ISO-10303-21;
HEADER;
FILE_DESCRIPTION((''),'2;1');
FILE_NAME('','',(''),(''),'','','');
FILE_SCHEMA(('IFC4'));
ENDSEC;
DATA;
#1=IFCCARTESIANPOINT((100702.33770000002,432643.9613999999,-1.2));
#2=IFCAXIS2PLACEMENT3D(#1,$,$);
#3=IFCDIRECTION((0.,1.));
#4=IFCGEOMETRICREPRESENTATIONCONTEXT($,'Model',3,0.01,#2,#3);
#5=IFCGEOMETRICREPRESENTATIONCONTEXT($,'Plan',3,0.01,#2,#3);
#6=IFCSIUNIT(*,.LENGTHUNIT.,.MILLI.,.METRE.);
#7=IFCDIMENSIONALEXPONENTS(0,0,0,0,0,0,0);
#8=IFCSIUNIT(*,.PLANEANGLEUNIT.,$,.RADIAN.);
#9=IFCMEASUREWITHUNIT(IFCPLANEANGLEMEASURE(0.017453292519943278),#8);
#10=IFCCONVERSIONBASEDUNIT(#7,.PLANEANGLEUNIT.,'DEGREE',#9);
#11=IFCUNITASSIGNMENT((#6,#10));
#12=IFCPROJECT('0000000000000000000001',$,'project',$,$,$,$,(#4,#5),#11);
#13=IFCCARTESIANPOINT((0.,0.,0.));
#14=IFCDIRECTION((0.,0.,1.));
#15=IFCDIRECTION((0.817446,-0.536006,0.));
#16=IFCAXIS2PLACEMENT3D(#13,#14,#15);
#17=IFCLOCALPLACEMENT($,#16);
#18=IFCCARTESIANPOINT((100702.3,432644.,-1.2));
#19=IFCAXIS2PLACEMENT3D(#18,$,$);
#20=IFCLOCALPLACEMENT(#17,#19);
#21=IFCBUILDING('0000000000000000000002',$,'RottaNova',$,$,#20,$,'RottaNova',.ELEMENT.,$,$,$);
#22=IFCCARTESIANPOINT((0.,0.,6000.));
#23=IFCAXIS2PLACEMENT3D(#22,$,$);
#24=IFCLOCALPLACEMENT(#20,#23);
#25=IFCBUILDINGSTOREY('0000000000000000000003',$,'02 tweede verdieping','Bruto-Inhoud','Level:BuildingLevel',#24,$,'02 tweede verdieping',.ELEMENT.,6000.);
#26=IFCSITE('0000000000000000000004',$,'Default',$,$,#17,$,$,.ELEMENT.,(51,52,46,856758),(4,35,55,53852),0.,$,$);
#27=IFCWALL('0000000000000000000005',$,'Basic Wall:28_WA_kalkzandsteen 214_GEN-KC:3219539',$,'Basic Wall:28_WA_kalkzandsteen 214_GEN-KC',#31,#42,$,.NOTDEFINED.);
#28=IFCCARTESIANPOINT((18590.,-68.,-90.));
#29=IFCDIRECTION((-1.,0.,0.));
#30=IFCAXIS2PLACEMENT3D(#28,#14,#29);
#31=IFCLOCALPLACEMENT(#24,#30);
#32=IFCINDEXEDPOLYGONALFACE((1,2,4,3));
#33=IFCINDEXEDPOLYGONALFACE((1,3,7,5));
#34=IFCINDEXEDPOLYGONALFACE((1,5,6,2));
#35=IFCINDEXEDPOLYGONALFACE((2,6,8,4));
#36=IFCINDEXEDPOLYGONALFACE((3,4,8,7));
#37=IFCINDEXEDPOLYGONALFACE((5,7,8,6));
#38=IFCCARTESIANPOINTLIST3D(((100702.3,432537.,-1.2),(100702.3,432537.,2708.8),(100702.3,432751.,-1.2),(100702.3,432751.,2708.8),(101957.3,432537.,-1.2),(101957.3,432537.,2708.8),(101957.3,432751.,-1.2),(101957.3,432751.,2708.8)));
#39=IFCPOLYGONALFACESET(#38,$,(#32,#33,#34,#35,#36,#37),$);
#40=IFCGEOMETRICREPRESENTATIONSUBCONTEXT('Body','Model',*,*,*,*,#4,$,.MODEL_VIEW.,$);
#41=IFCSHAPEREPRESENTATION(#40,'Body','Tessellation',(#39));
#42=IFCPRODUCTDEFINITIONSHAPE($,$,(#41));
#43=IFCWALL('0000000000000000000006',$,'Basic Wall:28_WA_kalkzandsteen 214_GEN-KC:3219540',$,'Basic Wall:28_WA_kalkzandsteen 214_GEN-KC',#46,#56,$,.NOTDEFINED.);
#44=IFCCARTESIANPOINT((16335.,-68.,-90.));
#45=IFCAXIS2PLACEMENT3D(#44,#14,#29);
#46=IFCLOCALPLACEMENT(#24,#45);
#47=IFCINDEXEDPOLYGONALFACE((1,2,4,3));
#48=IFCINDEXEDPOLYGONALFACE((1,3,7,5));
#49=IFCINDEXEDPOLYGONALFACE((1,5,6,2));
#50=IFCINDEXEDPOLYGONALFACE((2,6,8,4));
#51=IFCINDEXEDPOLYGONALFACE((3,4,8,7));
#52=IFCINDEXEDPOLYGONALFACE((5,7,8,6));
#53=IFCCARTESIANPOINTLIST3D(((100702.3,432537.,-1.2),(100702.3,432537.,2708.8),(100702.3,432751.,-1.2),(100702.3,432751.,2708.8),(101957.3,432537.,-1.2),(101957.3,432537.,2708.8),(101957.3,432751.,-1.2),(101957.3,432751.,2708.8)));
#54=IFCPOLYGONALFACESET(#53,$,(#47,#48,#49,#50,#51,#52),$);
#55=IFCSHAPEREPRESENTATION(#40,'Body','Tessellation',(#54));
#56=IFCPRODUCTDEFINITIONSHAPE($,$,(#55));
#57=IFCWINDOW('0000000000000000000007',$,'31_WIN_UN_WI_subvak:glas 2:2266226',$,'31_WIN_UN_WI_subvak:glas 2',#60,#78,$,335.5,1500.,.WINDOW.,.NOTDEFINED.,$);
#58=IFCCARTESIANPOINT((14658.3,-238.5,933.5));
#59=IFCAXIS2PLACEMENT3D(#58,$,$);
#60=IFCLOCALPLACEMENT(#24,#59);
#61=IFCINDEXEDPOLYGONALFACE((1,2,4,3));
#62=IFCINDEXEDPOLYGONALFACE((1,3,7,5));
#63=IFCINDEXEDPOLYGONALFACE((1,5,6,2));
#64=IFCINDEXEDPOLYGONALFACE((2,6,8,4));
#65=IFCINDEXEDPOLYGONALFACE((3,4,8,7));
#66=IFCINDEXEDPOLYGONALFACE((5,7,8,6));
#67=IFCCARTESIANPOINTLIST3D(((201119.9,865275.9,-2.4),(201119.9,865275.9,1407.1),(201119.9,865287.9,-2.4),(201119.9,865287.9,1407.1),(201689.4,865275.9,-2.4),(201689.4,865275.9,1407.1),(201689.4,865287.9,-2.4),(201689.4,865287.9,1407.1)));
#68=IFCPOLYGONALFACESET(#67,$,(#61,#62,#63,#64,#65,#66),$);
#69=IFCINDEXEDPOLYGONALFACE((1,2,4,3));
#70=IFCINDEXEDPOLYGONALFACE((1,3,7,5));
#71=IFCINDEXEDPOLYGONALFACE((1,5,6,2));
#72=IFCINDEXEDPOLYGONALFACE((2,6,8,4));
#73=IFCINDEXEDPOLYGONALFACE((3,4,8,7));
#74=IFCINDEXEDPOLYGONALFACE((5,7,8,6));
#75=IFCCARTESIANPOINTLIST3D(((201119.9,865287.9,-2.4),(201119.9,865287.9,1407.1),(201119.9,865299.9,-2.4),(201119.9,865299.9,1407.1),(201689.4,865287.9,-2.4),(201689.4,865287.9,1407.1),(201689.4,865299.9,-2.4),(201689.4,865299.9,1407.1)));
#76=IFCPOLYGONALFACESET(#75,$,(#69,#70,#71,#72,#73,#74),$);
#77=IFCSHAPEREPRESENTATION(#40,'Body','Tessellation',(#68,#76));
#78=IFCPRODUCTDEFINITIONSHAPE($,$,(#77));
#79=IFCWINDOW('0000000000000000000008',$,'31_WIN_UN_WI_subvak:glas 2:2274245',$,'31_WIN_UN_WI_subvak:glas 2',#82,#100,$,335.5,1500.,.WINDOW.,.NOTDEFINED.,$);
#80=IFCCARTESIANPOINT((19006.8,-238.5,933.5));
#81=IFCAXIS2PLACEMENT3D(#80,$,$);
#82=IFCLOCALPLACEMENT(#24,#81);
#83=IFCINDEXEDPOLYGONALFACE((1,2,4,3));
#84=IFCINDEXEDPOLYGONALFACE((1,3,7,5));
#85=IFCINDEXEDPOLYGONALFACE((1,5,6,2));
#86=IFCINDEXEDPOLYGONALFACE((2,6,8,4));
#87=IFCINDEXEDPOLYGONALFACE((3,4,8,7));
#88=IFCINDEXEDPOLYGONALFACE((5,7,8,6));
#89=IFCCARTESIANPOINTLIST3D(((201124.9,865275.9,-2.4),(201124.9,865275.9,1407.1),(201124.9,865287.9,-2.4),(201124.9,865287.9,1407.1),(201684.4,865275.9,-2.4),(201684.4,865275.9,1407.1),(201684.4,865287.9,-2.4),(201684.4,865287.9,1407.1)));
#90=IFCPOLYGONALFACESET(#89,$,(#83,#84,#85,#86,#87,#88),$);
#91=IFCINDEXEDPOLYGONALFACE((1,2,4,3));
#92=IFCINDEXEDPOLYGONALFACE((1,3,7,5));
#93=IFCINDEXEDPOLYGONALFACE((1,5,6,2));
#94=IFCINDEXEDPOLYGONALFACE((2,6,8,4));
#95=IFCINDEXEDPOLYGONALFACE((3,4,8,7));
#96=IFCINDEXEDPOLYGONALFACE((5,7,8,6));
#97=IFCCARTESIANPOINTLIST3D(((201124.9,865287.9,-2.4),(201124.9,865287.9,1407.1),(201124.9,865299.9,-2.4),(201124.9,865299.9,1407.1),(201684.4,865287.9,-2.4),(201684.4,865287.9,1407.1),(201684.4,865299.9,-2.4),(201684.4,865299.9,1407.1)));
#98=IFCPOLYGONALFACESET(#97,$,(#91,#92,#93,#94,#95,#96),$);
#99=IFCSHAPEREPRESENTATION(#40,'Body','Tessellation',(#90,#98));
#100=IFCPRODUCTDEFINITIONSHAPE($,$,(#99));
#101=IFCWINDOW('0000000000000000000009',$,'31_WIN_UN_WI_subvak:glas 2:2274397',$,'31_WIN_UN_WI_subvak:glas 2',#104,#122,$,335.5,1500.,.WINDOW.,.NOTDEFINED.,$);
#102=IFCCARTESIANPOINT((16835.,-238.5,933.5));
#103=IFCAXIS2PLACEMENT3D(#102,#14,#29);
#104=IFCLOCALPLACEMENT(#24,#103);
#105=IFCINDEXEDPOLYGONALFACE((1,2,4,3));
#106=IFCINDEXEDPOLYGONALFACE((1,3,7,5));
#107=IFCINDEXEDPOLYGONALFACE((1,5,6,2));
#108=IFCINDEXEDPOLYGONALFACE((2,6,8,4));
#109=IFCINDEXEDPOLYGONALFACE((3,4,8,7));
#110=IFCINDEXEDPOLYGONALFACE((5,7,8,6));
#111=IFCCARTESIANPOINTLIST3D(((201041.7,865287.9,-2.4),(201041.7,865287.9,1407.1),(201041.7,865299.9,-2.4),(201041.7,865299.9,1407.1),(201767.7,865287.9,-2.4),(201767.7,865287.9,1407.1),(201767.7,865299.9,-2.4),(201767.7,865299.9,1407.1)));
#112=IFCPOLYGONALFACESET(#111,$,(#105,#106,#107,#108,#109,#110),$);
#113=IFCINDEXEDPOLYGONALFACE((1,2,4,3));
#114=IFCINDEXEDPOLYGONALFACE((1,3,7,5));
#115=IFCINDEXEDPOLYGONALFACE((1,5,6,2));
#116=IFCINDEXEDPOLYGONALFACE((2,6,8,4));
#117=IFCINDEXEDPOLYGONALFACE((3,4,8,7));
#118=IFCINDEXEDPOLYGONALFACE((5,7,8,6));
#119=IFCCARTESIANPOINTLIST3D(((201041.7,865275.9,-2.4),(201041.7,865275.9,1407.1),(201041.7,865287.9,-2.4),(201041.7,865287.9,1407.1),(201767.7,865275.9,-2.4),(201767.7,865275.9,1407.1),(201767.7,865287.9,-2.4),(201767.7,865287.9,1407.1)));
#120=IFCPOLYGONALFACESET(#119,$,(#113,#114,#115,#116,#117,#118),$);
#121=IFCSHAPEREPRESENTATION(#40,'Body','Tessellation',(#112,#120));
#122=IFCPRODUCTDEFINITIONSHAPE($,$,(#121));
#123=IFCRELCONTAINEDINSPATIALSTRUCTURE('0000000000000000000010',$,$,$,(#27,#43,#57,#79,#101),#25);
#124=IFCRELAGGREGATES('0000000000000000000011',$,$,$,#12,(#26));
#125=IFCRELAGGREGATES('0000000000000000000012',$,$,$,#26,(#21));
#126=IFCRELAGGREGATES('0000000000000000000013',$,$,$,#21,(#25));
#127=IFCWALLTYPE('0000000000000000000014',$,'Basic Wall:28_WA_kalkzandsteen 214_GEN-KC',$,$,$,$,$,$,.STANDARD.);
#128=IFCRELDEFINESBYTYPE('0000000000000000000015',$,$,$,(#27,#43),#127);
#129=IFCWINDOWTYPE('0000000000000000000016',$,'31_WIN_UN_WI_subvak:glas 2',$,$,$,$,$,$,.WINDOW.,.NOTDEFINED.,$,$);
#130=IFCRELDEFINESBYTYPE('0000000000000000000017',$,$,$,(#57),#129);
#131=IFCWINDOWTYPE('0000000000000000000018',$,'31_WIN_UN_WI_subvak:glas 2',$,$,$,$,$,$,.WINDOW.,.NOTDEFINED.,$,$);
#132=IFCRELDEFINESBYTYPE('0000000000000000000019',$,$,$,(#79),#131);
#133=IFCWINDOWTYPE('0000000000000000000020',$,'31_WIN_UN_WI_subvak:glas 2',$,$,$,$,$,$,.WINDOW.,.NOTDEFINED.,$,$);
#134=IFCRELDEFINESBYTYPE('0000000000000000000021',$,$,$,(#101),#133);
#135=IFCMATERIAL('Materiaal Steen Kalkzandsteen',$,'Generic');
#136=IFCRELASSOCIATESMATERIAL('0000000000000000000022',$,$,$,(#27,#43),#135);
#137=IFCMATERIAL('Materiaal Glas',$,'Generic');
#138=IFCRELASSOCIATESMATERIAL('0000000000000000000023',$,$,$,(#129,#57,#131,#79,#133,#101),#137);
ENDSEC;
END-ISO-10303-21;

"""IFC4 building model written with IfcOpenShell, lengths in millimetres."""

from ifc_helpers import new_model, entity, si_unit, converted_unit, direction, frame, place, context, subcontext, project, spatial, indexed_curve, outline, extrude, source, transform, mapped, material, type_object, type_shapes, element, save


model = new_model("IFC4")

# Units and contexts
model_context = context("Model", 3, precision=0.01, world=frame((100702.33770000002, 432643.9613999999, -1.2)), true_north=direction((0.0, 1.0)))
plan_context = context("Plan", 3, precision=0.01, world=frame((100702.33770000002, 432643.9613999999, -1.2)), true_north=direction((0.0, 1.0)))
body_context = subcontext(model_context, "Body", "Model", "MODEL_VIEW")
ifc_project = project(units=[si_unit("LENGTHUNIT", "METRE", prefix="MILLI"), converted_unit("PLANEANGLEUNIT", "DEGREE", entity("IfcPlaneAngleMeasure", 0.017453292519943278), si_unit("PLANEANGLEUNIT", "RADIAN"), dimensions=[0, 0, 0, 0, 0, 0, 0])], contexts=[model_context, plan_context])

# Site, building, storey
site_placement = place(None, frame((0.0, 0.0, 0.0), z_axis=(0.0, 0.0, 1.0), x_axis=(0.817446, -0.536006, 0.0)))
site = spatial("IfcSite", under=ifc_project, at=site_placement, Name="Default", CompositionType="ELEMENT", RefLatitude=(51, 52, 46, 856758), RefLongitude=(4, 35, 55, 53852), RefElevation=0.0)
building_placement = place(site_placement, frame((100702.3, 432644.0, -1.2)))
building = spatial("IfcBuilding", under=site, at=building_placement, Name="RottaNova", LongName="RottaNova", CompositionType="ELEMENT")
storey_placement = place(building_placement, frame((0.0, 0.0, 6000.0)))
storey = spatial("IfcBuildingStorey", under=building, at=storey_placement, Name="02 tweede verdieping", Description="Bruto-Inhoud", ObjectType="Level:BuildingLevel", LongName="02 tweede verdieping", CompositionType="ELEMENT", Elevation=6000.0)

# Shared definitions
ifc_material_1 = material(Name="Materiaal Glas", Category="Generic")

# Walls
ifc_material_2 = material(Name="Materiaal Steen Kalkzandsteen", Category="Generic")
wall_type = type_object("IfcWallType", Name="Basic Wall:28_WA_kalkzandsteen 214_GEN-KC", PredefinedType="STANDARD")
wall_1_placement = place(storey_placement, frame((18590.0, -68.0, -90.0), z_axis=(0.0, 0.0, 1.0), x_axis=(-1.0, 0.0, 0.0)))
element("IfcWall", 1, at=wall_1_placement, inside=storey, type_object=wall_type, material=ifc_material_2, Name="Basic Wall:28_WA_kalkzandsteen 214_GEN-KC:3219539", ObjectType="Basic Wall:28_WA_kalkzandsteen 214_GEN-KC", PredefinedType="NOTDEFINED", context=body_context, shape_type="SweptSolid", body=[
    extrude(outline(indexed_curve([(1255.0, 107.0), (0.0, 107.0), (0.0, -107.0), (1255.0, -107.0), (1255.0, 107.0)], self_intersect=False)), frame((100702.3, 432644.0, -1.2)), (0.0, 0.0, 1.0), 2710.0),
])
wall_2_placement = place(storey_placement, frame((16335.0, -68.0, -90.0), z_axis=(0.0, 0.0, 1.0), x_axis=(-1.0, 0.0, 0.0)))
element("IfcWall", 2, at=wall_2_placement, inside=storey, type_object=wall_type, material=ifc_material_2, Name="Basic Wall:28_WA_kalkzandsteen 214_GEN-KC:3219540", ObjectType="Basic Wall:28_WA_kalkzandsteen 214_GEN-KC", PredefinedType="NOTDEFINED", context=body_context, shape_type="SweptSolid", body=[
    extrude(outline(indexed_curve([(1255.0, 107.0), (0.0, 107.0), (0.0, -107.0), (1255.0, -107.0), (1255.0, 107.0)], self_intersect=False)), frame((100702.3, 432644.0, -1.2)), (0.0, 0.0, 1.0), 2710.0),
])

# Windows
window_type_1 = type_object("IfcWindowType", Name="31_WIN_UN_WI_subvak:glas 2", PartitioningType="NOTDEFINED", PredefinedType="WINDOW", material=ifc_material_1)
shared_shape_1 = source(frame((100702.3, 432644.0, -1.2)), body_context, "Body", "SweptSolid", [
    extrude(outline(indexed_curve([(-284.7, -6.0), (284.7, -6.0), (284.7, 6.0), (-284.7, 6.0), (-284.7, -6.0)], self_intersect=False)), frame((0.0, -6.0, 0.0)), (0.0, 0.0, 1.0), 1409.5),
    extrude(outline(indexed_curve([(-284.8, -6.0), (284.8, -6.0), (284.8, 6.0), (-284.8, 6.0), (-284.8, -6.0)], self_intersect=False)), frame((0.0, 6.0, 0.0)), (0.0, 0.0, 1.0), 1409.5),
])
type_shapes(window_type_1, [shared_shape_1])
window_1_placement = place(storey_placement, frame((14658.3, -238.5, 933.5)))
element("IfcWindow", 3, at=window_1_placement, inside=storey, type_object=window_type_1, material=ifc_material_1, Name="31_WIN_UN_WI_subvak:glas 2:2266226", ObjectType="31_WIN_UN_WI_subvak:glas 2", OverallHeight=335.5, OverallWidth=1500.0, PartitioningType="NOTDEFINED", PredefinedType="WINDOW", context=body_context, shape_type="MappedRepresentation", body=[
    mapped(shared_shape_1, transform((100702.3, 432644.0, -1.2), scale=1.0)),
])
window_type_2 = type_object("IfcWindowType", Name="31_WIN_UN_WI_subvak:glas 2", PartitioningType="NOTDEFINED", PredefinedType="WINDOW", material=ifc_material_1)
shared_shape_2 = source(frame((100702.3, 432644.0, -1.2)), body_context, "Body", "SweptSolid", [
    extrude(outline(indexed_curve([(-279.8, -6.0), (279.8, -6.0), (279.8, 6.0), (-279.8, 6.0), (-279.8, -6.0)], self_intersect=False)), frame((0.0, -6.0, 0.0)), (0.0, 0.0, 1.0), 1409.5),
    extrude(outline(indexed_curve([(-279.8, -6.0), (279.8, -6.0), (279.8, 6.0), (-279.8, 6.0), (-279.8, -6.0)], self_intersect=False)), frame((0.0, 6.0, 0.0)), (0.0, 0.0, 1.0), 1409.5),
])
type_shapes(window_type_2, [shared_shape_2])
window_2_placement = place(storey_placement, frame((19006.8, -238.5, 933.5)))
element("IfcWindow", 4, at=window_2_placement, inside=storey, type_object=window_type_2, material=ifc_material_1, Name="31_WIN_UN_WI_subvak:glas 2:2274245", ObjectType="31_WIN_UN_WI_subvak:glas 2", OverallHeight=335.5, OverallWidth=1500.0, PartitioningType="NOTDEFINED", PredefinedType="WINDOW", context=body_context, shape_type="MappedRepresentation", body=[
    mapped(shared_shape_2, transform((100702.3, 432644.0, -1.2), scale=1.0)),
])
window_type_3 = type_object("IfcWindowType", Name="31_WIN_UN_WI_subvak:glas 2", PartitioningType="NOTDEFINED", PredefinedType="WINDOW", material=ifc_material_1)
shared_shape_3 = source(frame((100702.3, 432644.0, -1.2)), body_context, "Body", "SweptSolid", [
    extrude(outline(indexed_curve([(-6.0, -363.0), (6.0, -363.0), (6.0, 363.0), (-6.0, 363.0), (-6.0, -363.0)], self_intersect=False)), frame((0.0, 6.0, 0.0), z_axis=(0.0, 0.0, 1.0), x_axis=(0.0, -1.0, 0.0)), (0.0, 0.0, 1.0), 1409.5),
    extrude(outline(indexed_curve([(-6.0, -363.0), (6.0, -363.0), (6.0, 363.0), (-6.0, 363.0), (-6.0, -363.0)], self_intersect=False)), frame((0.0, -6.0, 0.0), z_axis=(0.0, 0.0, 1.0), x_axis=(0.0, -1.0, 0.0)), (0.0, 0.0, 1.0), 1409.5),
])
type_shapes(window_type_3, [shared_shape_3])
window_3_placement = place(storey_placement, frame((16835.0, -238.5, 933.5), z_axis=(0.0, 0.0, 1.0), x_axis=(-1.0, 0.0, 0.0)))
element("IfcWindow", 5, at=window_3_placement, inside=storey, type_object=window_type_3, material=ifc_material_1, Name="31_WIN_UN_WI_subvak:glas 2:2274397", ObjectType="31_WIN_UN_WI_subvak:glas 2", OverallHeight=335.5, OverallWidth=1500.0, PartitioningType="NOTDEFINED", PredefinedType="WINDOW", context=body_context, shape_type="MappedRepresentation", body=[
    mapped(shared_shape_3, transform((100702.3, 432644.0, -1.2), scale=1.0)),
])

save(model, "model.ifc")
